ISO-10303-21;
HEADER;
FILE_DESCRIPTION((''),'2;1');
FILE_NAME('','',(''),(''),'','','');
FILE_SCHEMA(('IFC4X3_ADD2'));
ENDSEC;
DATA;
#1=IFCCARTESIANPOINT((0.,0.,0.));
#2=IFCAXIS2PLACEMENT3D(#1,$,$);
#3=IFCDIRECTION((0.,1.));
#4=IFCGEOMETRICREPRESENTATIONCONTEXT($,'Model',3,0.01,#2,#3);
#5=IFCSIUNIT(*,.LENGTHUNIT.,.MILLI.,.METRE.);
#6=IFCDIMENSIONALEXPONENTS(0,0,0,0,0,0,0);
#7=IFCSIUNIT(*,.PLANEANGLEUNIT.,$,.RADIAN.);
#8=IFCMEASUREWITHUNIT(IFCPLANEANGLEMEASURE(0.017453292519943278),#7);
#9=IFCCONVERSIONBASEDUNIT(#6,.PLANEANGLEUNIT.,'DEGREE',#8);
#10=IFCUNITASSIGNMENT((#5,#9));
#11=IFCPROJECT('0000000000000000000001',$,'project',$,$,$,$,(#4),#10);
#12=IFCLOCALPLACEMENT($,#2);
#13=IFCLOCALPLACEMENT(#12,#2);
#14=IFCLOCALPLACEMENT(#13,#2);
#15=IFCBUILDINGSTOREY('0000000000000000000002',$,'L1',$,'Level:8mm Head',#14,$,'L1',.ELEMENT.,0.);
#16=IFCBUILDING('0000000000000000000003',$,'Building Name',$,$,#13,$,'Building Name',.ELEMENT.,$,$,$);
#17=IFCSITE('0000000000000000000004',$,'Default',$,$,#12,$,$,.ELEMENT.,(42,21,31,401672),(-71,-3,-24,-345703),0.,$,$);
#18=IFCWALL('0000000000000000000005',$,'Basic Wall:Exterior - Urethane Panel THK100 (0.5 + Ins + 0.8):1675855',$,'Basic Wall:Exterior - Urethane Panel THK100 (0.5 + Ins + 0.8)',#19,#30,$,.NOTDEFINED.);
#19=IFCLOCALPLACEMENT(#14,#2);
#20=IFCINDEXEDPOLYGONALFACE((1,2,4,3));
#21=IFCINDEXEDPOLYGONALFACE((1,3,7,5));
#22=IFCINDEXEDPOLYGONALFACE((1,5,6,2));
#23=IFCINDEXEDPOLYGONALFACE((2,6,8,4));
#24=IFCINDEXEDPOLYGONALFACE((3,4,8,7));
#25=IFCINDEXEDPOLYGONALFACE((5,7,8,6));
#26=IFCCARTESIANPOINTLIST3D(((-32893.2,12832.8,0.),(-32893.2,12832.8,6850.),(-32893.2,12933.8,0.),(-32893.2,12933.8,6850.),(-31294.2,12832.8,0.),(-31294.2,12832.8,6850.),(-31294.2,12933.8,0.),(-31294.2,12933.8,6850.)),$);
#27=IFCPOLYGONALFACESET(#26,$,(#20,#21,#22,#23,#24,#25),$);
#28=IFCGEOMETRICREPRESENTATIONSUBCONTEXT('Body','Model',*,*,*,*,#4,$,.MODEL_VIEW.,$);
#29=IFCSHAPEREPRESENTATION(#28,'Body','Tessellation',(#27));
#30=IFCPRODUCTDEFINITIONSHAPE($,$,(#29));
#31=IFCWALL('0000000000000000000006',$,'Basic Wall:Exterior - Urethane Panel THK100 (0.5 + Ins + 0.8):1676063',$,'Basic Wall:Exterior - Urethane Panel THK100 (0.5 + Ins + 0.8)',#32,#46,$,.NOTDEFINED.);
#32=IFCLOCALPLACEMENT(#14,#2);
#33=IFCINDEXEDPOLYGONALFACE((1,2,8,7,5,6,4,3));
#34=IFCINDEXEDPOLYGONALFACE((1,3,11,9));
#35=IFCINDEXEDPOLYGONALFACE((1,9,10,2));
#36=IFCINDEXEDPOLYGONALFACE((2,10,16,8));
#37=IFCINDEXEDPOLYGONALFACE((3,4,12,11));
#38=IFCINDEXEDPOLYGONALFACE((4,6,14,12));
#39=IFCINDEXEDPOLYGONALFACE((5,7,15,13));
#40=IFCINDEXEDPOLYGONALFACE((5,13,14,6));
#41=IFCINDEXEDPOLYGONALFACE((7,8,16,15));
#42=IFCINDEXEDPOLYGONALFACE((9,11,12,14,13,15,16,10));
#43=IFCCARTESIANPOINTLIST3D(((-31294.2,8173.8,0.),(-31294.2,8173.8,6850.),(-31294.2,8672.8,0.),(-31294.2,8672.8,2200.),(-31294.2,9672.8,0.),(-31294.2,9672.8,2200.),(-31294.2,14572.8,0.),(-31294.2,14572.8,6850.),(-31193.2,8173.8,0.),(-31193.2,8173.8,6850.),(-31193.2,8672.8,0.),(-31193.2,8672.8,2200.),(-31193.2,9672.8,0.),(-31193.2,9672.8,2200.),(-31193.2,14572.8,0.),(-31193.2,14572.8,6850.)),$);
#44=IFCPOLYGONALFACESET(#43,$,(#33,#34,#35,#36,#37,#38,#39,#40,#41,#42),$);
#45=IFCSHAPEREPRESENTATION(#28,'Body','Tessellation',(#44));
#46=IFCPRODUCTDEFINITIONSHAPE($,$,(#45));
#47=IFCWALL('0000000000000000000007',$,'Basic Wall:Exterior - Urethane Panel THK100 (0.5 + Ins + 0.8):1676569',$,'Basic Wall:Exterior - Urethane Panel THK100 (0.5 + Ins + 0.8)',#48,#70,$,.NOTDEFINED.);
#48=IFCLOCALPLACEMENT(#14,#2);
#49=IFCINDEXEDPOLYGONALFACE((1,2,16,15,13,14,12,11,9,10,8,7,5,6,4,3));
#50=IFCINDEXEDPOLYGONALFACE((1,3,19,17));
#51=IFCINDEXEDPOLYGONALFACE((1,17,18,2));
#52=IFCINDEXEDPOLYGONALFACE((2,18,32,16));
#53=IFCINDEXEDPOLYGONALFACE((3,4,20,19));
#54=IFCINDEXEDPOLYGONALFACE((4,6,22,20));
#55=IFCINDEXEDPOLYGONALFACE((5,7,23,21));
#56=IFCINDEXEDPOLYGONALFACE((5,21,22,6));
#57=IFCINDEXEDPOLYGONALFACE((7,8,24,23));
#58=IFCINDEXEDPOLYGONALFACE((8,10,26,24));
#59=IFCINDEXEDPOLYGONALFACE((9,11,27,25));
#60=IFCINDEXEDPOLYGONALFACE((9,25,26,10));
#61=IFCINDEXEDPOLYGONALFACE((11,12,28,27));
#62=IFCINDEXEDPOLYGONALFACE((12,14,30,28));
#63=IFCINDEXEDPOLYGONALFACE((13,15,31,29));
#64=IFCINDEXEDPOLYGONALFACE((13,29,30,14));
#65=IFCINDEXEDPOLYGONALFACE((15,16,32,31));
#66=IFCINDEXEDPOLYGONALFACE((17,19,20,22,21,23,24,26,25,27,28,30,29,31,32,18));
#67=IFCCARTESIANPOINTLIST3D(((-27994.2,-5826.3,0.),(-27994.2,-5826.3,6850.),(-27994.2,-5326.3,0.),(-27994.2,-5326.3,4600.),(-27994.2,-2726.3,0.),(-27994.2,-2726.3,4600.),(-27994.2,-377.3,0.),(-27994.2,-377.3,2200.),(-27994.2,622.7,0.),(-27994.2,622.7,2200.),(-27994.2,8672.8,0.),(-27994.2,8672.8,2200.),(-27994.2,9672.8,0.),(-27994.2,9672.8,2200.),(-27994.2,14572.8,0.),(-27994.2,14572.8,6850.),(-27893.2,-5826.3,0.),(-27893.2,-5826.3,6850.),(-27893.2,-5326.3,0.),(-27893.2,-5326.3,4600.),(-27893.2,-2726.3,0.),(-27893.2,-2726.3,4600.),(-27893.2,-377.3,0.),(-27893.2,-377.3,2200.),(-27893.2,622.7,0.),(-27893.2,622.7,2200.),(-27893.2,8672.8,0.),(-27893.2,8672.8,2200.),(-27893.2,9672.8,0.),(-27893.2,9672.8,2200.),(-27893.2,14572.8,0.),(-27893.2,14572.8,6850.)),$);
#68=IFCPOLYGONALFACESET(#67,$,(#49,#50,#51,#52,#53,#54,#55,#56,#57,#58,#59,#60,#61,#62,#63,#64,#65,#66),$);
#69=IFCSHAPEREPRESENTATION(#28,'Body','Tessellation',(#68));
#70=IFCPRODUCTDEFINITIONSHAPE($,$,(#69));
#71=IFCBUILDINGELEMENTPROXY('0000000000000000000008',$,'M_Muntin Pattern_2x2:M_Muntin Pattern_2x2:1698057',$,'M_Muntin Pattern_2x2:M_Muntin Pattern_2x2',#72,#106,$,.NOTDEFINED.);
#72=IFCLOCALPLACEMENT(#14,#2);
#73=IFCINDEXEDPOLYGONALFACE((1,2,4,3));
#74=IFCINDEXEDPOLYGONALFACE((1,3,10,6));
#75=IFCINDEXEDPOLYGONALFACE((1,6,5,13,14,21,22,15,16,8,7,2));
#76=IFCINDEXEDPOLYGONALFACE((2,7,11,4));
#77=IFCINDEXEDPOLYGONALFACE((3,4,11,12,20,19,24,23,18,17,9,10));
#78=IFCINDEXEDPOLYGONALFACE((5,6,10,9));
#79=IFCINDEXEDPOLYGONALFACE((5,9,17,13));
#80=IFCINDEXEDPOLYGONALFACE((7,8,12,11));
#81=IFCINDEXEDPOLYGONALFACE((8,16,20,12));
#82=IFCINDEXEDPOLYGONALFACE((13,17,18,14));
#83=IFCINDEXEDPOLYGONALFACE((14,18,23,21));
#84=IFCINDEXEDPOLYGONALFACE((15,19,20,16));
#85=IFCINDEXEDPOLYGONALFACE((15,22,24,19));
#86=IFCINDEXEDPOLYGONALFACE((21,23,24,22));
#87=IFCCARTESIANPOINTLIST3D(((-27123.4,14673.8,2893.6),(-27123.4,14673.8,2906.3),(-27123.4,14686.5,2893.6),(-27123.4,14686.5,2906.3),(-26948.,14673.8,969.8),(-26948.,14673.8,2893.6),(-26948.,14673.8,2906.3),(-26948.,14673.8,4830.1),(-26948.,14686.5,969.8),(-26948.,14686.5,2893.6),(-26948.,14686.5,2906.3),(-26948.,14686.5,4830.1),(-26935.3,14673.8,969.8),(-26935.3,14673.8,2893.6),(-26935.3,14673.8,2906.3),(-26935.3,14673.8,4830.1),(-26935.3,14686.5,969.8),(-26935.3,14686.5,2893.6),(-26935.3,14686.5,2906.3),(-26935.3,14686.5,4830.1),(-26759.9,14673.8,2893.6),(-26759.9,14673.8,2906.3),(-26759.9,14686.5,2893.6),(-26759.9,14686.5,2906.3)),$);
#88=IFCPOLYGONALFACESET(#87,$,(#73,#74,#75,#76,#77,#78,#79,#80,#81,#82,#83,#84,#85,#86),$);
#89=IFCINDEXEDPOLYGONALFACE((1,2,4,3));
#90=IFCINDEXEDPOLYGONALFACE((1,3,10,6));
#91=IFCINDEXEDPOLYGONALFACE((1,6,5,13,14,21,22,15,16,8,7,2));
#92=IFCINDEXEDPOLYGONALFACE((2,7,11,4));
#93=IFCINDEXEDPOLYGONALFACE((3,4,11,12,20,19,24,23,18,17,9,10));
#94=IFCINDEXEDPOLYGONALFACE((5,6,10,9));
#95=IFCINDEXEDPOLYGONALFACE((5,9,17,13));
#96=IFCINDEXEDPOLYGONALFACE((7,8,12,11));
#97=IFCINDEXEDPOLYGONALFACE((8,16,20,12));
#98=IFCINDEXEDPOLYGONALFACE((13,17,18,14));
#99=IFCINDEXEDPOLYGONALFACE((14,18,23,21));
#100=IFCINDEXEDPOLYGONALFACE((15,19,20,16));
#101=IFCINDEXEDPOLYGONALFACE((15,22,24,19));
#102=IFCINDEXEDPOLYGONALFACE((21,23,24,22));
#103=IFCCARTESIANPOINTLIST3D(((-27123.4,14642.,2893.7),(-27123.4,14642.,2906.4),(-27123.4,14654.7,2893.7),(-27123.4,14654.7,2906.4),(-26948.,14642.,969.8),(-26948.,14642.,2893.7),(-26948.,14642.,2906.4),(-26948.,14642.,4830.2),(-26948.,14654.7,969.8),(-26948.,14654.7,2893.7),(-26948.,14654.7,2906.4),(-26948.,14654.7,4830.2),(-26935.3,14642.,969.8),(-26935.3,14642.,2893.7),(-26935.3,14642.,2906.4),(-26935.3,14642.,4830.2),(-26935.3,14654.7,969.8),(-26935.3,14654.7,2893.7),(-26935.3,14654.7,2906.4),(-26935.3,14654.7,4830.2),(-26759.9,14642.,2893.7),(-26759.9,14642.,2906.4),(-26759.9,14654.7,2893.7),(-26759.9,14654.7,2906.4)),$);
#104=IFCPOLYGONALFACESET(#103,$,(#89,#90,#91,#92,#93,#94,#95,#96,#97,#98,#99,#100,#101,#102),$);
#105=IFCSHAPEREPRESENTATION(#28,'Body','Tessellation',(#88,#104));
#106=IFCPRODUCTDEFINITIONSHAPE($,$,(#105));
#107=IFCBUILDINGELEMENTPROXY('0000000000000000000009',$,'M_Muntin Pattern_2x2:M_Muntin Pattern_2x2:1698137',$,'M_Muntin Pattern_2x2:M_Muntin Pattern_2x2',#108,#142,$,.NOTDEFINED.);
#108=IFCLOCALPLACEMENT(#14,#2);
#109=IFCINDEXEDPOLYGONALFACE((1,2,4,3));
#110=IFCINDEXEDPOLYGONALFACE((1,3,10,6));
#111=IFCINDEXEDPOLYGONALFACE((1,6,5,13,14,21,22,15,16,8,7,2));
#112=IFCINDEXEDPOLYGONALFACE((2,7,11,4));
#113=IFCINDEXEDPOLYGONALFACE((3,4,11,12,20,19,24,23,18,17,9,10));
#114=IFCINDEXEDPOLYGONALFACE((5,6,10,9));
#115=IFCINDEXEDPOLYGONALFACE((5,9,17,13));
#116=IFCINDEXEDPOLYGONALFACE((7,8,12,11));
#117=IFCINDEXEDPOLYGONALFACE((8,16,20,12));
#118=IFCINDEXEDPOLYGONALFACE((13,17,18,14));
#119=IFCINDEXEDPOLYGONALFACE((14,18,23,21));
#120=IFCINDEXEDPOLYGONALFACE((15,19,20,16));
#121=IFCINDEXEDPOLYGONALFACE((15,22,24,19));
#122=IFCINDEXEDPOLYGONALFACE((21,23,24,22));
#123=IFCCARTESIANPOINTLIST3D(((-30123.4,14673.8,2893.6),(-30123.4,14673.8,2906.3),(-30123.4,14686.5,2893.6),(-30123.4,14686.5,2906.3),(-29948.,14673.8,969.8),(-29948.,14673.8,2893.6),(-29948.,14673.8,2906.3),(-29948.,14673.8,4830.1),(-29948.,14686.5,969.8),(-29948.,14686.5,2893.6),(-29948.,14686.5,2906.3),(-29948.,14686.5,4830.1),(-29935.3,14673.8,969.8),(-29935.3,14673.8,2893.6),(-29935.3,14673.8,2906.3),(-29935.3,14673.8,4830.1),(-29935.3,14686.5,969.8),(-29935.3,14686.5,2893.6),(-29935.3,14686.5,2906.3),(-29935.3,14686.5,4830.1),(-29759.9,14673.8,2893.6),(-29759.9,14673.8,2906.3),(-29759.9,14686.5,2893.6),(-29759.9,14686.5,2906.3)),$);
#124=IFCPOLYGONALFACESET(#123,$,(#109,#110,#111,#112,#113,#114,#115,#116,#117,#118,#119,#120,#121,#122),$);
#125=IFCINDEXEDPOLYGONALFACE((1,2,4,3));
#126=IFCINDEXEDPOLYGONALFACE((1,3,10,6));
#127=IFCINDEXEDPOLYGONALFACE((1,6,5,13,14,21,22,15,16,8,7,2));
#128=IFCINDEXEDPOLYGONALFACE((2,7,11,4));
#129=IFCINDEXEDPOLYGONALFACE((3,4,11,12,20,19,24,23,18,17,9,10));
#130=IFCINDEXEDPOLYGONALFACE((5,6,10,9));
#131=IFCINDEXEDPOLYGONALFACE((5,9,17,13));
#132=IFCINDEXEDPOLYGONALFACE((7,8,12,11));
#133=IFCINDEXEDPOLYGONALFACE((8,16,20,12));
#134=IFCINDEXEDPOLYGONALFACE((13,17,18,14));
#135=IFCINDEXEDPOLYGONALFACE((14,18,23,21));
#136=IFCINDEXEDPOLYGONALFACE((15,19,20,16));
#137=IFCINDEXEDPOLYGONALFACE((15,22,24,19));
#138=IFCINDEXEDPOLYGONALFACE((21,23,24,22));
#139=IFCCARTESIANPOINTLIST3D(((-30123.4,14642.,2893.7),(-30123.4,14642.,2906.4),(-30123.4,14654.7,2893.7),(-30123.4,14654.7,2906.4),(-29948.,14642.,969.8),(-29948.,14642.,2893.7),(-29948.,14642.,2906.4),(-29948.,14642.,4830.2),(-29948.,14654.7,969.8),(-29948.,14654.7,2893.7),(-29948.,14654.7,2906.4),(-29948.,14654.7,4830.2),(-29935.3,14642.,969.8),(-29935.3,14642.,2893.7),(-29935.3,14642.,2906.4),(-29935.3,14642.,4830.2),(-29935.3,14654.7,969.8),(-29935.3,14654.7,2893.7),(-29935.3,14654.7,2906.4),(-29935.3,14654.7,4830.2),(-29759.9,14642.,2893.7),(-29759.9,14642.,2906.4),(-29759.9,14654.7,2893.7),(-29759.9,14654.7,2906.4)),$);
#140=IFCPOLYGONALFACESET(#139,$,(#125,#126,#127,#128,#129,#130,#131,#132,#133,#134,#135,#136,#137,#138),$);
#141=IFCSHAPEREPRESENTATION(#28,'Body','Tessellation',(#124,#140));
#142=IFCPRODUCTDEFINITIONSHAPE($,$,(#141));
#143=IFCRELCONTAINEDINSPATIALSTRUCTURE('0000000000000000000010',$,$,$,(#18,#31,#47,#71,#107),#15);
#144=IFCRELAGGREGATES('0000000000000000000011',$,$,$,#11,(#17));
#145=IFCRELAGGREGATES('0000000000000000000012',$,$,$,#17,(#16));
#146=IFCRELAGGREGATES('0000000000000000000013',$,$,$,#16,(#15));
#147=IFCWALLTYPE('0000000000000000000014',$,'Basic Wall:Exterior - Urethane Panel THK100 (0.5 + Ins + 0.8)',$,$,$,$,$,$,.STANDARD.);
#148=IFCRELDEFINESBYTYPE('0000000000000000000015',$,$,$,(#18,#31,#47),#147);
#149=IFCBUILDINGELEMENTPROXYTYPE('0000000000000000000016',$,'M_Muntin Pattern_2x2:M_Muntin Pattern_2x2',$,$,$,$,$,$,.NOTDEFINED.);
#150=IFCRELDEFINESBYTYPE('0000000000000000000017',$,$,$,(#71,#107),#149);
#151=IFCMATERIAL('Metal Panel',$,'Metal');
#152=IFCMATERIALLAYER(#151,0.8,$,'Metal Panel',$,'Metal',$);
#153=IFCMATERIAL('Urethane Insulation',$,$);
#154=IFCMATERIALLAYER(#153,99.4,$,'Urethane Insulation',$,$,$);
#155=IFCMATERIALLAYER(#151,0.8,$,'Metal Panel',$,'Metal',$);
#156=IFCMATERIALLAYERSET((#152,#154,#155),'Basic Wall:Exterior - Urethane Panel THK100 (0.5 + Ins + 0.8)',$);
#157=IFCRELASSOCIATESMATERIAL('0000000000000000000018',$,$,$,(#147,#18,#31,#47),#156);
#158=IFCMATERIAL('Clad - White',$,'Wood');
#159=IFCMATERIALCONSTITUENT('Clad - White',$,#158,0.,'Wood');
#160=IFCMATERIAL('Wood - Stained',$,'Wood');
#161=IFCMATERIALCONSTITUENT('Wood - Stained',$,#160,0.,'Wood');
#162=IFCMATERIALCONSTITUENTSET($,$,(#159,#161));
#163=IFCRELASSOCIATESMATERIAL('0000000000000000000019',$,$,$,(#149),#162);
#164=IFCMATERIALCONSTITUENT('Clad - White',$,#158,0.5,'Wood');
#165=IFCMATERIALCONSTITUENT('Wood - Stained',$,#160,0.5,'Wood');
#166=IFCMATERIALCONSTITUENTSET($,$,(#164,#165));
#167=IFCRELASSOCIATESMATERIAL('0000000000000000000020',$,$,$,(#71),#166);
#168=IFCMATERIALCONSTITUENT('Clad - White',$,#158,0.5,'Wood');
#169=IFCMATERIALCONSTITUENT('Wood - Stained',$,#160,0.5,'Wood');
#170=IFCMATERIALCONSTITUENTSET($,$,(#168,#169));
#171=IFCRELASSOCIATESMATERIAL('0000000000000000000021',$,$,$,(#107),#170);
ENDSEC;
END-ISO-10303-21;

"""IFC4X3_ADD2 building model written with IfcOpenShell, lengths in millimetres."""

from ifc_helpers import new_model, entity, si_unit, converted_unit, direction, frame, frame_2d, origin, place, context, subcontext, project, spatial, polyline, rectangle, outline, extrude, clip, bounded_halfspace, source, transform, mapped, material, layer, layer_set, constituent, constituent_set, type_object, type_shapes, element, save


model = new_model("IFC4X3_ADD2")

# Units and contexts
model_context = context("Model", 3, precision=0.01, world=origin(), true_north=direction((0.0, 1.0)))
body_context = subcontext(model_context, "Body", "Model", "MODEL_VIEW")
ifc_project = project(units=[si_unit("LENGTHUNIT", "METRE", prefix="MILLI"), converted_unit("PLANEANGLEUNIT", "DEGREE", entity("IfcPlaneAngleMeasure", 0.017453292519943278), si_unit("PLANEANGLEUNIT", "RADIAN"), dimensions=[0, 0, 0, 0, 0, 0, 0])], contexts=[model_context])

# Site, building, storey
site_placement = place(None, origin())
site = spatial("IfcSite", under=ifc_project, at=site_placement, Name="Default", CompositionType="ELEMENT", RefLatitude=(42, 21, 31, 401672), RefLongitude=(-71, -3, -24, -345703), RefElevation=0.0)
building_placement = place(site_placement, origin())
building = spatial("IfcBuilding", under=site, at=building_placement, Name="Building Name", LongName="Building Name", CompositionType="ELEMENT")
storey_placement = place(building_placement, origin())
storey = spatial("IfcBuildingStorey", under=building, at=storey_placement, Name="L1", ObjectType="Level:8mm Head", LongName="L1", CompositionType="ELEMENT", Elevation=0.0)

# Shared definitions
ifc_material_1 = material(Name="Metal Panel", Category="Metal")
ifc_layer_1 = layer(ifc_material_1, 0.8, Name="Metal Panel", Category="Metal")
ifc_material_2 = material(Name="Urethane Insulation")
ifc_layer_2 = layer(ifc_material_2, 99.4, Name="Urethane Insulation")
ifc_layer_3 = layer(ifc_material_1, 0.8, Name="Metal Panel", Category="Metal")
ifc_layer_set = layer_set([ifc_layer_1, ifc_layer_2, ifc_layer_3], Name="Basic Wall:Exterior - Urethane Panel THK100 (0.5 + Ins + 0.8)")
wall_type = type_object("IfcWallType", Name="Basic Wall:Exterior - Urethane Panel THK100 (0.5 + Ins + 0.8)", PredefinedType="STANDARD", material=ifc_layer_set)

# Wall
wall_1_placement = place(storey_placement, frame((-32893.2, 12883.3, 0.0)))
element("IfcWall", 1, at=wall_1_placement, inside=storey, type_object=wall_type, material=ifc_layer_set, Name="Basic Wall:Exterior - Urethane Panel THK100 (0.5 + Ins + 0.8):1675855", ObjectType="Basic Wall:Exterior - Urethane Panel THK100 (0.5 + Ins + 0.8)", PredefinedType="NOTDEFINED", context=body_context, shape_type="Clipping", body=[
    clip(extrude(rectangle(XDim=1599.0, YDim=101.0, at=frame_2d((799.5, 0.0), x_axis=(-1.0, 0.0))), origin(), (0.0, 0.0, 1.0), 6850.0), bounded_halfspace(frame((0.0, -50.5, 6850.0), z_axis=(0.0, 0.0, -1.0), x_axis=(1.0, 0.0, 0.0)), True, frame((0.0, -50.5, 6850.0)), polyline([(0.0, 0.0), (1599.0, 0.0), (1599.0, 101.0), (0.0, 101.0), (0.0, 0.0)]))),
])

# Wall, opening
wall_2_placement = place(storey_placement, frame((-31243.7, 14572.8, 0.0), z_axis=(0.0, 0.0, 1.0), x_axis=(0.0, -1.0, 0.0)))
wall_2 = element("IfcWall", 2, at=wall_2_placement, inside=storey, type_object=wall_type, material=ifc_layer_set, Name="Basic Wall:Exterior - Urethane Panel THK100 (0.5 + Ins + 0.8):1676063", ObjectType="Basic Wall:Exterior - Urethane Panel THK100 (0.5 + Ins + 0.8)", PredefinedType="NOTDEFINED", context=body_context, shape_type="Clipping", body=[
    clip(extrude(rectangle(XDim=6399.0, YDim=101.0, at=frame_2d((3199.5, 0.0), x_axis=(-1.0, 0.0))), origin(), (0.0, 0.0, 1.0), 6850.0), bounded_halfspace(frame((0.0, -50.5, 6850.0), z_axis=(0.0, 0.0, -1.0), x_axis=(0.0, 1.0, 0.0)), True, frame((0.0, -50.5, 6850.0)), polyline([(0.0, 0.0), (1639.0, 0.0), (1740.0, 0.0), (6399.0, 0.0), (6399.0, 101.0), (0.0, 101.0), (0.0, 0.0)]))),
])
opening_1_placement = place(wall_2_placement, frame((5900.0, 50.5, 0.0)))
element("IfcOpeningElement", 3, at=opening_1_placement, cuts=wall_2, PredefinedType="OPENING", context=body_context, shape_type="SweptSolid", body=[
    extrude(rectangle(XDim=2200.0, YDim=1000.0, at=frame_2d((1100.0, 500.0), x_axis=(1.0, 0.0))), frame((0.0, 0.0, 0.0), z_axis=(0.0, -1.0, 0.0), x_axis=(0.0, 0.0, 1.0)), (0.0, 0.0, 1.0), 101.0),
])

# Wall, openings
wall_3_placement = place(storey_placement, frame((-27943.7, 14572.8, 0.0), z_axis=(0.0, 0.0, 1.0), x_axis=(0.0, -1.0, 0.0)))
wall_3 = element("IfcWall", 4, at=wall_3_placement, inside=storey, type_object=wall_type, material=ifc_layer_set, Name="Basic Wall:Exterior - Urethane Panel THK100 (0.5 + Ins + 0.8):1676569", ObjectType="Basic Wall:Exterior - Urethane Panel THK100 (0.5 + Ins + 0.8)", PredefinedType="NOTDEFINED", context=body_context, shape_type="Clipping", body=[
    clip(extrude(rectangle(XDim=20399.1, YDim=101.0, at=frame_2d((10199.5, 0.0), x_axis=(-1.0, 0.0))), origin(), (0.0, 0.0, 1.0), 6850.0), bounded_halfspace(frame((0.0, -50.5, 6850.0), z_axis=(0.0, 0.0, -1.0), x_axis=(0.0, 1.0, 0.0)), True, frame((0.0, -50.5, 6850.0)), polyline([(0.0, 0.0), (6399.0, 0.0), (6500.0, 0.0), (10899.1, 0.0), (11000.1, 0.0), (12899.1, 0.0), (13000.1, 0.0), (16399.1, 0.0), (16500.1, 0.0), (20399.1, 0.0), (20399.1, 101.0), (0.0, 101.0), (0.0, 0.0)]))),
])
opening_2_placement = place(wall_3_placement, frame((5900.0, 50.5, 0.0)))
element("IfcOpeningElement", 5, at=opening_2_placement, cuts=wall_3, PredefinedType="OPENING", context=body_context, shape_type="SweptSolid", body=[
    extrude(rectangle(XDim=2200.0, YDim=1000.0, at=frame_2d((1100.0, 500.0), x_axis=(1.0, 0.0))), frame((0.0, 0.0, 0.0), z_axis=(0.0, -1.0, 0.0), x_axis=(0.0, 0.0, 1.0)), (0.0, 0.0, 1.0), 101.0),
])
opening_3_placement = place(wall_3_placement, frame((14950.1, 50.5, 0.0)))
element("IfcOpeningElement", 6, at=opening_3_placement, cuts=wall_3, PredefinedType="OPENING", context=body_context, shape_type="SweptSolid", body=[
    extrude(rectangle(XDim=2200.0, YDim=1000.0, at=frame_2d((1100.0, 500.0), x_axis=(1.0, 0.0))), frame((0.0, 0.0, 0.0), z_axis=(0.0, -1.0, 0.0), x_axis=(0.0, 0.0, 1.0)), (0.0, 0.0, 1.0), 101.0),
])
opening_4_placement = place(wall_3_placement, frame((17299.1, -50.5, 0.0)))
element("IfcOpeningElement", 7, at=opening_4_placement, cuts=wall_3, PredefinedType="OPENING", context=body_context, shape_type="SweptSolid", body=[
    extrude(rectangle(XDim=4600.0, YDim=2600.0, at=frame_2d((2300.0, 1300.0), x_axis=(1.0, 0.0))), frame((0.0, 0.0, 0.0), z_axis=(0.0, 1.0, 0.0), x_axis=(0.0, 0.0, 1.0)), (0.0, 0.0, 1.0), 101.0),
])

# Building element proxies
ifc_material_3 = material(Name="Clad - White", Category="Wood")
ifc_constituent_1 = constituent(ifc_material_3, Name="Clad - White", Category="Wood", fraction=0.5)
ifc_material_4 = material(Name="Wood - Stained", Category="Wood")
ifc_constituent_2 = constituent(ifc_material_4, Name="Wood - Stained", Category="Wood", fraction=0.5)
ifc_constituent_set_1 = constituent_set(constituents=[ifc_constituent_1, ifc_constituent_2])
ifc_constituent_3 = constituent(ifc_material_3, Name="Clad - White", Category="Wood", fraction=0.0)
ifc_constituent_4 = constituent(ifc_material_4, Name="Wood - Stained", Category="Wood", fraction=0.0)
ifc_constituent_set_2 = constituent_set(constituents=[ifc_constituent_3, ifc_constituent_4])
building_element_proxy_type_1 = type_object("IfcBuildingElementProxyType", Name="M_Muntin Pattern_2x2:M_Muntin Pattern_2x2", PredefinedType="NOTDEFINED", material=ifc_constituent_set_2)
shared_shape_1 = source(origin(), body_context, "Body", "SweptSolid", [
    extrude(outline(polyline([(6.4, -6.4), (1930.1, -6.4), (1930.1, 6.3), (6.4, 6.3), (6.4, 181.7), (-6.3, 181.7), (-6.3, 6.3), (-1930.2, 6.3), (-1930.2, -6.4), (-6.3, -6.4), (-6.3, -181.7), (6.4, -181.7), (6.4, -6.4)])), frame((0.0, 9.5, 1930.1), z_axis=(0.0, 1.0, 0.0), x_axis=(0.0, 0.0, 1.0)), (0.0, 0.0, 1.0), 12.7),
    extrude(outline(polyline([(6.4, -6.4), (1930.2, -6.4), (1930.2, 6.3), (6.4, 6.3), (6.4, 181.7), (-6.3, 181.7), (-6.3, 6.3), (-1930.2, 6.3), (-1930.2, -6.4), (-6.3, -6.4), (-6.3, -181.7), (6.4, -181.7), (6.4, -6.4)])), frame((0.0, -22.2, 1930.2), z_axis=(0.0, 1.0, 0.0), x_axis=(0.0, 0.0, 1.0)), (0.0, 0.0, 1.0), 12.7),
])
type_shapes(building_element_proxy_type_1, [shared_shape_1])
proxy_1_placement = place(storey_placement, frame((-26941.6, 14664.3, 969.8)))
element("IfcBuildingElementProxy", 8, at=proxy_1_placement, inside=storey, type_object=building_element_proxy_type_1, material=ifc_constituent_set_1, Name="M_Muntin Pattern_2x2:M_Muntin Pattern_2x2:1698057", ObjectType="M_Muntin Pattern_2x2:M_Muntin Pattern_2x2", PredefinedType="NOTDEFINED", context=body_context, shape_type="MappedRepresentation", body=[
    mapped(shared_shape_1, transform((0.0, 0.0, 0.0), scale=1.0)),
])
ifc_constituent_5 = constituent(ifc_material_3, Name="Clad - White", Category="Wood", fraction=0.5)
ifc_constituent_6 = constituent(ifc_material_4, Name="Wood - Stained", Category="Wood", fraction=0.5)
ifc_constituent_set_3 = constituent_set(constituents=[ifc_constituent_5, ifc_constituent_6])
proxy_2_placement = place(storey_placement, frame((-29941.6, 14664.3, 969.8)))
element("IfcBuildingElementProxy", 9, at=proxy_2_placement, inside=storey, type_object=building_element_proxy_type_1, material=ifc_constituent_set_3, Name="M_Muntin Pattern_2x2:M_Muntin Pattern_2x2:1698137", ObjectType="M_Muntin Pattern_2x2:M_Muntin Pattern_2x2", PredefinedType="NOTDEFINED", context=body_context, shape_type="MappedRepresentation", body=[
    mapped(shared_shape_1, transform((0.0, 0.0, 0.0), scale=1.0)),
])

save(model, "model.ifc")
